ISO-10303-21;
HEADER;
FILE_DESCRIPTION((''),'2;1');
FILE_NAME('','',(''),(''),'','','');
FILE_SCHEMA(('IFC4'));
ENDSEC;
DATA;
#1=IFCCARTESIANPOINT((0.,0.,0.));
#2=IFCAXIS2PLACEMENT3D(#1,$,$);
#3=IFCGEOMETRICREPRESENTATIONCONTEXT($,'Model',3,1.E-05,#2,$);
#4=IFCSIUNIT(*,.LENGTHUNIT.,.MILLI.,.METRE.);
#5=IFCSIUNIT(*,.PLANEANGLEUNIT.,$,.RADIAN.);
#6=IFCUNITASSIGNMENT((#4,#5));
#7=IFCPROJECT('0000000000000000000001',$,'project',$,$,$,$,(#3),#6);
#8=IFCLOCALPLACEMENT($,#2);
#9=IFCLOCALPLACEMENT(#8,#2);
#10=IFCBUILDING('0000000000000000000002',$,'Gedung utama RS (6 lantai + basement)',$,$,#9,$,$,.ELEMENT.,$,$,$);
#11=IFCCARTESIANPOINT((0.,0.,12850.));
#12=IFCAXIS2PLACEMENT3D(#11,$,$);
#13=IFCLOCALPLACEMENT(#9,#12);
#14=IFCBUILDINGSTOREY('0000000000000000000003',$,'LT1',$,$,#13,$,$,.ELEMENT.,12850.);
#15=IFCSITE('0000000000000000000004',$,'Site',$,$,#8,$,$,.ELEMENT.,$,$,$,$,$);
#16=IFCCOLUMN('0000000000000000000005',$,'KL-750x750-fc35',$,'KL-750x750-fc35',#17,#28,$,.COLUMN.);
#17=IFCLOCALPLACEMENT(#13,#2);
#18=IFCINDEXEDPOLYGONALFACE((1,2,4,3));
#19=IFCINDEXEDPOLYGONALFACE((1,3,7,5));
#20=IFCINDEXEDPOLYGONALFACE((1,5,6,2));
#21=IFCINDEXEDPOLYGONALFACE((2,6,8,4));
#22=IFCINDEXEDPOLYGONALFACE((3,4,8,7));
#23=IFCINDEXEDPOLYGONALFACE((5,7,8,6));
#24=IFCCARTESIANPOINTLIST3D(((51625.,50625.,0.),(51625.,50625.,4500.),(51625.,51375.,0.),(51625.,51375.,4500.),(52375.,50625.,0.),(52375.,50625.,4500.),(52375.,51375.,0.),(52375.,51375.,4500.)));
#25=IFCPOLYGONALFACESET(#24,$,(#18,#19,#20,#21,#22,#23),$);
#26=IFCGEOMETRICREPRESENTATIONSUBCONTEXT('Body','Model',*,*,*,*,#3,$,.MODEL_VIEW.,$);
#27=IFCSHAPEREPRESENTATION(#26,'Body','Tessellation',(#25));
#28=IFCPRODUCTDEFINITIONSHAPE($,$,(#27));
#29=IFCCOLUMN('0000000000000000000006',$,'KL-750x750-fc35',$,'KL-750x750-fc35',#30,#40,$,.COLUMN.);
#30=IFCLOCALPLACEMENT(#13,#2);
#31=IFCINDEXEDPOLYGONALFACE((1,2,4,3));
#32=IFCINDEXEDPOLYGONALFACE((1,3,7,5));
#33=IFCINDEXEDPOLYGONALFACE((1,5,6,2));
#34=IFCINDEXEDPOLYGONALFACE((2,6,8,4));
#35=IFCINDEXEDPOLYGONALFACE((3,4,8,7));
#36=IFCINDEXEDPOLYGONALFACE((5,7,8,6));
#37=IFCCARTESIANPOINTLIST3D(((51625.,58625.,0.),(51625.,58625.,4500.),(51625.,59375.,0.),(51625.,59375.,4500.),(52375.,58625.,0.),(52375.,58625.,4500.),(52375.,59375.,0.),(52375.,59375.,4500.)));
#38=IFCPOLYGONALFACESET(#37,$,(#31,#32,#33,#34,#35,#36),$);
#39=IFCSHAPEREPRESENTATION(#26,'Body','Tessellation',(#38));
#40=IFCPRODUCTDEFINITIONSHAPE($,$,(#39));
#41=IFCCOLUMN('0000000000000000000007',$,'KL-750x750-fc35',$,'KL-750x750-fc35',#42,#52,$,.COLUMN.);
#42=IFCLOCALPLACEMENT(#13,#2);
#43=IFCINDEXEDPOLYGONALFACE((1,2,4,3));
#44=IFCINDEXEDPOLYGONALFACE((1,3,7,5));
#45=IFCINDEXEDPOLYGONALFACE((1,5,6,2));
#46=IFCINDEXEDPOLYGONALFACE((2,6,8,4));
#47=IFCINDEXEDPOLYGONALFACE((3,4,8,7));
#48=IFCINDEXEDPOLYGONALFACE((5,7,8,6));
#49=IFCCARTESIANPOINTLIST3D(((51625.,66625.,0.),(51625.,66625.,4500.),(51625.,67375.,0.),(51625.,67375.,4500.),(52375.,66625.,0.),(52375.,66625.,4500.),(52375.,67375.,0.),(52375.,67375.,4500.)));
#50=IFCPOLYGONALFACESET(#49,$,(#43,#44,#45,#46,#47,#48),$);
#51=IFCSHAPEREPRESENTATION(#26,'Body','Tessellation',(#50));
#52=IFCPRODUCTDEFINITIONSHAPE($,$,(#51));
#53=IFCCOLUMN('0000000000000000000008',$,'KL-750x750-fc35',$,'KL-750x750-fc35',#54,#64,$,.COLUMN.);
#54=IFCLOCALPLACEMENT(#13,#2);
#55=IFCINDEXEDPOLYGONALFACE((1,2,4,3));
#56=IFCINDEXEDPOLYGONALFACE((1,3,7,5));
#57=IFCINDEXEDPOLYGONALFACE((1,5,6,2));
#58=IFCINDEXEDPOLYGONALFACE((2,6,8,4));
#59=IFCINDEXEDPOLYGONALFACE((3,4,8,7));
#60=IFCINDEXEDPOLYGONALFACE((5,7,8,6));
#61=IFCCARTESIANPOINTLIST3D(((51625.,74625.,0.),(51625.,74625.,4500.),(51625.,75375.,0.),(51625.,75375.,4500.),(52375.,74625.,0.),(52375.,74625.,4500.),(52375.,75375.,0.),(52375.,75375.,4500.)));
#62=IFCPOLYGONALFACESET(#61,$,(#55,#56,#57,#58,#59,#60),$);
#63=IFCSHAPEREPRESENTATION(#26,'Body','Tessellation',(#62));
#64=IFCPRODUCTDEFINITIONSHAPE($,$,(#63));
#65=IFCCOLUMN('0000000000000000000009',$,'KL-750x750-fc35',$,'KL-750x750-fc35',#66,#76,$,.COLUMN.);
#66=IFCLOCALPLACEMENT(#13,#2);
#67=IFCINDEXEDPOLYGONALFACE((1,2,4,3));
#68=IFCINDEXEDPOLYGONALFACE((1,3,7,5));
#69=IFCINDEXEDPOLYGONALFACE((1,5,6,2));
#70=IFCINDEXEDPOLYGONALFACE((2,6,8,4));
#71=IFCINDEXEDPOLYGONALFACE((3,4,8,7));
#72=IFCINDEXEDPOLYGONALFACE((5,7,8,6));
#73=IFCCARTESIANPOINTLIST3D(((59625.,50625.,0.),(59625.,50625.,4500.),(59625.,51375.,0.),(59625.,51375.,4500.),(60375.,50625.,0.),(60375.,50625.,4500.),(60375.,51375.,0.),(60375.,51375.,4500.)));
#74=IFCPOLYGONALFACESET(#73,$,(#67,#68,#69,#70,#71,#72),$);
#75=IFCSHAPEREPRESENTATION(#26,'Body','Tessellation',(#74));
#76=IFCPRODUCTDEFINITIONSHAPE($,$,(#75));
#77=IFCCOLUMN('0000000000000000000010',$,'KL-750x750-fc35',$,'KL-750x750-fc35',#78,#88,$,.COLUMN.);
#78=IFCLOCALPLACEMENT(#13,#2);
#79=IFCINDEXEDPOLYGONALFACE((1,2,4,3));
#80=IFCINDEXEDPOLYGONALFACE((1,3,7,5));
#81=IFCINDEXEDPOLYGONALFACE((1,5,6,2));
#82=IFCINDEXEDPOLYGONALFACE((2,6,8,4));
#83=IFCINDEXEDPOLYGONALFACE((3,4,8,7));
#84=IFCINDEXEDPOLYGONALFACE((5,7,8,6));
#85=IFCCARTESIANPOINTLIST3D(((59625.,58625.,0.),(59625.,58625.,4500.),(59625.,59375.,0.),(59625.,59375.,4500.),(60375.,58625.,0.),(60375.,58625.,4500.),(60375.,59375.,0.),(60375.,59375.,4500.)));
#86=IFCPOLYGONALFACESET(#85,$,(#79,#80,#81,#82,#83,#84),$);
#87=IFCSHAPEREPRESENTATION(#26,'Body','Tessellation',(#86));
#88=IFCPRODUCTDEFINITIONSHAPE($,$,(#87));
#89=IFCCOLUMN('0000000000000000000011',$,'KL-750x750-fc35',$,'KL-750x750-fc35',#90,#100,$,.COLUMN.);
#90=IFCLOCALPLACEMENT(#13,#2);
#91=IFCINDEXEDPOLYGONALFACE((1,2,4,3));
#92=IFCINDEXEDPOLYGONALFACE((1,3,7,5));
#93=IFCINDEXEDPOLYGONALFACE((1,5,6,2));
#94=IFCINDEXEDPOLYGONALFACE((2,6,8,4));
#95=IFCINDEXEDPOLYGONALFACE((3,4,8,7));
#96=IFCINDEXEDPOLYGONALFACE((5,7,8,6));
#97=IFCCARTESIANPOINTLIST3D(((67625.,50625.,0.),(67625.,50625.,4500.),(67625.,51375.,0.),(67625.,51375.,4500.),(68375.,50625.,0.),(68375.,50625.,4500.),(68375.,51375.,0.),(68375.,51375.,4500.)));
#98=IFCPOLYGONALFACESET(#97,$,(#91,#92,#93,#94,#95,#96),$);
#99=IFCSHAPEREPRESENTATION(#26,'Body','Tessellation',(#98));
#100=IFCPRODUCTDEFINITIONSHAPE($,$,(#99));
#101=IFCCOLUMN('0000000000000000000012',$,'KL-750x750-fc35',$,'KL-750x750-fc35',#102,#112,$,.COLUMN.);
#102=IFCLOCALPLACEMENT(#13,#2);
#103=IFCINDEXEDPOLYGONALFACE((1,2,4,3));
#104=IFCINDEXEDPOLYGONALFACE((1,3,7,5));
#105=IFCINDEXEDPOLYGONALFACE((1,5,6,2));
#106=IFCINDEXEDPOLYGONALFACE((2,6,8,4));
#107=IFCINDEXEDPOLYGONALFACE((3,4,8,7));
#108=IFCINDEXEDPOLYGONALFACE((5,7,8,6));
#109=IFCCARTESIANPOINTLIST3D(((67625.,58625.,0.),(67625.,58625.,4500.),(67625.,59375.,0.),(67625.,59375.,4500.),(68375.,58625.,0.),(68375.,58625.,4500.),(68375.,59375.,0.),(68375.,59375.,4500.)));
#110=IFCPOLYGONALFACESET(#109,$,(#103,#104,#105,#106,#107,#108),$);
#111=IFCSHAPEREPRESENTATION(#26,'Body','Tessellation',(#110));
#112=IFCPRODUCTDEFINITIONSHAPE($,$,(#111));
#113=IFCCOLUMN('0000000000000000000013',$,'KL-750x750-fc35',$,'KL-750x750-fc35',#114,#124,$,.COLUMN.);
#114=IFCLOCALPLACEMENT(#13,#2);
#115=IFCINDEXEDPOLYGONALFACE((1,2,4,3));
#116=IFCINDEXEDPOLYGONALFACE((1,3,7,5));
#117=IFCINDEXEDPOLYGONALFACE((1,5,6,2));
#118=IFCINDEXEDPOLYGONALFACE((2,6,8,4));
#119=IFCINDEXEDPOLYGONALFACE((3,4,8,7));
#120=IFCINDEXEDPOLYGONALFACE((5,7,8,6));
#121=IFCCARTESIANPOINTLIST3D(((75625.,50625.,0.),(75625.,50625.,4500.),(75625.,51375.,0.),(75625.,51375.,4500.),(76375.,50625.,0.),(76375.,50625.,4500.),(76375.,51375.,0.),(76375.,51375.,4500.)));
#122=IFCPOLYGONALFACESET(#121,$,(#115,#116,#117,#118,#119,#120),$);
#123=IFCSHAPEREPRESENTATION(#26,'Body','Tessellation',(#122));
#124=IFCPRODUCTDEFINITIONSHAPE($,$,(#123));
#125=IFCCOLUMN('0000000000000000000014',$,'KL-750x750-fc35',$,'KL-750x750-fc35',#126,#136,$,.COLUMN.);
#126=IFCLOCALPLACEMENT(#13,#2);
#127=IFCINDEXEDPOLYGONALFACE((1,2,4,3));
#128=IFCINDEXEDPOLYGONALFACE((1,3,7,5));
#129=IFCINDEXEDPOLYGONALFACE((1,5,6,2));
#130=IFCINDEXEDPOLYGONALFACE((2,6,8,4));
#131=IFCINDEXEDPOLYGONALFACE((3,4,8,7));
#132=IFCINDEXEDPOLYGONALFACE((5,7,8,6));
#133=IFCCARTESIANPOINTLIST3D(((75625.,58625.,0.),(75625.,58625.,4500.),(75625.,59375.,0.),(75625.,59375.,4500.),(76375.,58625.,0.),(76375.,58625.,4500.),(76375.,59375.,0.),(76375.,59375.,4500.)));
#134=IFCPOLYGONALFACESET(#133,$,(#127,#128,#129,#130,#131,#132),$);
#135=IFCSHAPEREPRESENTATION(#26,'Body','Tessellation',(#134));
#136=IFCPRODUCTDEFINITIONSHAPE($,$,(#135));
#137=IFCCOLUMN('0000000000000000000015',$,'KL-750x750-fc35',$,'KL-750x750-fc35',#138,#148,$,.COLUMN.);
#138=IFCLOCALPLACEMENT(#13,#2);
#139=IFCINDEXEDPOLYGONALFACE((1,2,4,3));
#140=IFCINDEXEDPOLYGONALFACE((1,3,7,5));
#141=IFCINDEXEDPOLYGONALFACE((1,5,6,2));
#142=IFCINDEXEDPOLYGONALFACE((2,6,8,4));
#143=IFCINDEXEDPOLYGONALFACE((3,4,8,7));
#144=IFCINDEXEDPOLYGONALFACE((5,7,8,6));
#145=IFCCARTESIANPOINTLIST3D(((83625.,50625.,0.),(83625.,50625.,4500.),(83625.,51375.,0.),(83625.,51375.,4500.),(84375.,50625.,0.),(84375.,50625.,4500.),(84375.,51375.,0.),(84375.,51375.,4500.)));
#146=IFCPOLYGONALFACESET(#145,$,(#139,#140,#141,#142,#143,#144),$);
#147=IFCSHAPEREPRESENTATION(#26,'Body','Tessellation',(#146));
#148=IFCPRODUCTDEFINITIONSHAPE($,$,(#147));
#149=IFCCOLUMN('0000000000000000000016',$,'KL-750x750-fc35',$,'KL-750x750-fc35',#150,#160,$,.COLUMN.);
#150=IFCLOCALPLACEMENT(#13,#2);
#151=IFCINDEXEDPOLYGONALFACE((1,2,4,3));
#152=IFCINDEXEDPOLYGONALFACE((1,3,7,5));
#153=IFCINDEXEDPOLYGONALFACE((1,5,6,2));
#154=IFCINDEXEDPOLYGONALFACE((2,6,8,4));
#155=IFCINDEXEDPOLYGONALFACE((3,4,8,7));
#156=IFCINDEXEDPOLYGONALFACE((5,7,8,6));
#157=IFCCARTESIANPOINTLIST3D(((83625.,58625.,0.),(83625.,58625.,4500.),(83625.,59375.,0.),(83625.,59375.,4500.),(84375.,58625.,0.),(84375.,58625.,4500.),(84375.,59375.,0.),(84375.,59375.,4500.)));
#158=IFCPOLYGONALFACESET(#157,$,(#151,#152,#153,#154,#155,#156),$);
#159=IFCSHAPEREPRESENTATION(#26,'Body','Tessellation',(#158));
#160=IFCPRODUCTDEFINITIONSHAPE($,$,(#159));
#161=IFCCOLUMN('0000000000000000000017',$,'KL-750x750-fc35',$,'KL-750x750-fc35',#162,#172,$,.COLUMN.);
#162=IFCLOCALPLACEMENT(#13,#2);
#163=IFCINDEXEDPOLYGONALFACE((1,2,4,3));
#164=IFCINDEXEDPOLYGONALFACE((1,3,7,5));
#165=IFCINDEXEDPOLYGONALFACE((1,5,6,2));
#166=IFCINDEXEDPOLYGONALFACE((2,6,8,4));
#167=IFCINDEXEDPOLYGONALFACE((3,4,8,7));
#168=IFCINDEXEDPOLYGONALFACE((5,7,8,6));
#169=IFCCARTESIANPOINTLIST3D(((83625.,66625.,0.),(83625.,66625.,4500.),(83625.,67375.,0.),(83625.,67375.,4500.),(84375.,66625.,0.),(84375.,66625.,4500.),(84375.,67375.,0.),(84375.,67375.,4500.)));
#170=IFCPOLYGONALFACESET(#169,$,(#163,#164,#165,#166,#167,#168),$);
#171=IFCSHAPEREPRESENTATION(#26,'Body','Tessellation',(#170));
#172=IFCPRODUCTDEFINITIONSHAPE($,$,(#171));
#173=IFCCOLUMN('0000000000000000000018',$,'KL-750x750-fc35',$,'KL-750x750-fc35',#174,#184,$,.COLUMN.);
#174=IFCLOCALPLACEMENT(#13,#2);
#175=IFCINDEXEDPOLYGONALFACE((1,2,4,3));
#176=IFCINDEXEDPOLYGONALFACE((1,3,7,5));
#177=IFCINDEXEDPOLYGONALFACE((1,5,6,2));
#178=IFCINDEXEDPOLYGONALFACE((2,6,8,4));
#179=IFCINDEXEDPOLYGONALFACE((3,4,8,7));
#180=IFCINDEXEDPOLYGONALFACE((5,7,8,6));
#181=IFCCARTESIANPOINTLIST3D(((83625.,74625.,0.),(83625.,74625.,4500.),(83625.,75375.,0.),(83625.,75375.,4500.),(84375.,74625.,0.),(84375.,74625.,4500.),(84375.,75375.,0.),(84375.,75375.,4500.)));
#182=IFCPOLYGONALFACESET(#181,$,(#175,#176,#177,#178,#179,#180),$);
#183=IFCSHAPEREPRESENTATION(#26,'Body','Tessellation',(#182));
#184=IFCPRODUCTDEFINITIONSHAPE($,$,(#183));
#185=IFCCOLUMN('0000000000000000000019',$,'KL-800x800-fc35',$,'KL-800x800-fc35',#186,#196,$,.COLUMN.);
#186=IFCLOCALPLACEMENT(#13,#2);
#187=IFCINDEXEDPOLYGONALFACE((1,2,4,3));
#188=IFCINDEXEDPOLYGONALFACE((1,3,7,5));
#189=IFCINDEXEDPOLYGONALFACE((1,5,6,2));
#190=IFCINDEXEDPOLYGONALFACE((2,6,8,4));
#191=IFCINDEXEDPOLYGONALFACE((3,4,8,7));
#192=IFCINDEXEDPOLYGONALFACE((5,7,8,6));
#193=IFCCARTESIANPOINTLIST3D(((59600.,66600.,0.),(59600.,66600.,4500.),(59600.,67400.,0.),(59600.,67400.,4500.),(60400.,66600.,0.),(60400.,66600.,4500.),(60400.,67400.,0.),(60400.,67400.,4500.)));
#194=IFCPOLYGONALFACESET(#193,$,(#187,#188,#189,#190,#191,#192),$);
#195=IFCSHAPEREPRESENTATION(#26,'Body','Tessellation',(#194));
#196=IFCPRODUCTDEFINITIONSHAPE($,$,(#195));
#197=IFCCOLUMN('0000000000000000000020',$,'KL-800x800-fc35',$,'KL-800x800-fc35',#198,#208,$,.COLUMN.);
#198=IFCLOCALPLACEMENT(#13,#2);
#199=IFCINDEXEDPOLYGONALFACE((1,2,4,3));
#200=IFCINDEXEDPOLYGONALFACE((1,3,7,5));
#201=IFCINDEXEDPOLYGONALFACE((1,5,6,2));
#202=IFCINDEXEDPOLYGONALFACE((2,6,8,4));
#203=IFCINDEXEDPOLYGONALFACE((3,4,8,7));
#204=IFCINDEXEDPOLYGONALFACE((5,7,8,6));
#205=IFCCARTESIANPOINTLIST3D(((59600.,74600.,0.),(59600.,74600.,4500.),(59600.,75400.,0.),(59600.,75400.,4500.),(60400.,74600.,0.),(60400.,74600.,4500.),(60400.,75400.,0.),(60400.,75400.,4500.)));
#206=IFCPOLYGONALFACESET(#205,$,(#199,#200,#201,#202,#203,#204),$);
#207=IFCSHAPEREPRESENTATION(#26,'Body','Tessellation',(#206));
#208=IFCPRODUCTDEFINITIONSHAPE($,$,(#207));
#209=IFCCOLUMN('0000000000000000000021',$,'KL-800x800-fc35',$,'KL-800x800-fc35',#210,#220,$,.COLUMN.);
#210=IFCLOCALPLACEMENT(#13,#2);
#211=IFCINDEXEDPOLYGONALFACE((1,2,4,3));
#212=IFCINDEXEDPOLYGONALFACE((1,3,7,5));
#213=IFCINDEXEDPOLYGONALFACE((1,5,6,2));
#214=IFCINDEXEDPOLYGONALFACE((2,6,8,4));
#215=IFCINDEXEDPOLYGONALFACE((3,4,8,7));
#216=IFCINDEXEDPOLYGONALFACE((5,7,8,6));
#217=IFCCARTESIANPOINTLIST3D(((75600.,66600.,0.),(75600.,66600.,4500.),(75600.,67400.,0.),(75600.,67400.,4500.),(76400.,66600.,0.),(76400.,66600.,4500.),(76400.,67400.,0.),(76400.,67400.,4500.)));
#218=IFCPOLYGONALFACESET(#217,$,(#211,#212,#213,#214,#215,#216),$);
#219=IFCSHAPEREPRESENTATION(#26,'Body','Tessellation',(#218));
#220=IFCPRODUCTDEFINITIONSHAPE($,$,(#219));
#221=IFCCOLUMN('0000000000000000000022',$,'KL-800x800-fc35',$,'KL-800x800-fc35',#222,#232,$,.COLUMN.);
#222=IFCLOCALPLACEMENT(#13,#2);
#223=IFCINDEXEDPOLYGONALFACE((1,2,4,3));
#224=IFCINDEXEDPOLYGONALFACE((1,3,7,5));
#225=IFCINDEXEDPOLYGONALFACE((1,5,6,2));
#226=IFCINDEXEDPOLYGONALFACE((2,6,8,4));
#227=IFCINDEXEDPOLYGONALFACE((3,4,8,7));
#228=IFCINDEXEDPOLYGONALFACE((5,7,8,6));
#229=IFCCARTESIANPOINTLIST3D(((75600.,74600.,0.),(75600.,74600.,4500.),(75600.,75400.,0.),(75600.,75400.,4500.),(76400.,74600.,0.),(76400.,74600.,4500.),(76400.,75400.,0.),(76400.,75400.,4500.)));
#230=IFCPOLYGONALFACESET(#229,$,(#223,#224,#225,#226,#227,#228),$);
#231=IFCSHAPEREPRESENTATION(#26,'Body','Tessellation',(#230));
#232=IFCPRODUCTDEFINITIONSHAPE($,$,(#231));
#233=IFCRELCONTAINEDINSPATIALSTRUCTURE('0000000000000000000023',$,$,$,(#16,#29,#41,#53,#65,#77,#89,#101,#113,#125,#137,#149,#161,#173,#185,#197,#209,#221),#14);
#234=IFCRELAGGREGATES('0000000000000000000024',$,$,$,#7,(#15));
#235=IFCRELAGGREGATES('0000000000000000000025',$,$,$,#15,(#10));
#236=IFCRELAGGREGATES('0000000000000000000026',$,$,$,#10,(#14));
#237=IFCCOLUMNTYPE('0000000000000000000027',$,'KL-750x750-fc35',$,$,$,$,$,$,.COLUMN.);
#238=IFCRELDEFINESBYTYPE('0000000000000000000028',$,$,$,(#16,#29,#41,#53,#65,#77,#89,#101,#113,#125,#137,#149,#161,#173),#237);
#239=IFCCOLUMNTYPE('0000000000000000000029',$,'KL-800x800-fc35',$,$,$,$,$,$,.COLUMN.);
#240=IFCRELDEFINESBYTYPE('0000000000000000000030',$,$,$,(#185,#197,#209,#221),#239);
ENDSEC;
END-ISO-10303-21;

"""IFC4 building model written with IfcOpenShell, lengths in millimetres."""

from ifc_helpers import new_model, si_unit, frame, origin, origin_2d, place, context, subcontext, project, spatial, rectangle, extrude, material_profile, profile_set, profile_usage, type_object, element, save


model = new_model("IFC4")

# Units and contexts
model_context = context("Model", 3, precision=1e-05, world=origin())
body_context = subcontext(model_context, "Body", "Model", "MODEL_VIEW")
ifc_project = project(units=[si_unit("LENGTHUNIT", "METRE", prefix="MILLI"), si_unit("PLANEANGLEUNIT", "RADIAN")], contexts=[model_context])

# Site, building, storey
site_placement = place(None, origin())
site = spatial("IfcSite", under=ifc_project, at=site_placement, Name="Site", CompositionType="ELEMENT")
building_placement = place(site_placement, origin())
building = spatial("IfcBuilding", under=site, at=building_placement, Name="Gedung utama RS (6 lantai + basement)", CompositionType="ELEMENT")
storey_placement = place(building_placement, frame((0.0, 0.0, 12850.0)))
storey = spatial("IfcBuildingStorey", under=building, at=storey_placement, Name="LT1", CompositionType="ELEMENT", Elevation=12850.0)

# Columns
ifc_material_profile_1 = material_profile(None, rectangle(XDim=750.0, YDim=750.0, at=origin_2d()), Name="KL-750x750-fc35")
ifc_profile_set_1 = profile_set([ifc_material_profile_1], Name="KL-750x750-fc35")
ifc_profile_usage_1 = profile_usage(ifc_profile_set_1, cardinal=5)
column_type_1 = type_object("IfcColumnType", Name="KL-750x750-fc35", PredefinedType="COLUMN", material=ifc_profile_set_1)
for number, where, z_axis, x_axis, name in (
    (1, (52000.0, 51000.0, 0.0), (0.0, 0.0, 1.0), (1.0, 0.0, 0.0), "KL-750x750-fc35"),
    (2, (52000.0, 59000.0, 0.0), (0.0, 0.0, 1.0), (1.0, 0.0, 0.0), "KL-750x750-fc35"),
    (3, (52000.0, 67000.0, 0.0), (0.0, 0.0, 1.0), (1.0, 0.0, 0.0), "KL-750x750-fc35"),
    (4, (52000.0, 75000.0, 0.0), (0.0, 0.0, 1.0), (1.0, 0.0, 0.0), "KL-750x750-fc35"),
    (5, (60000.0, 51000.0, 0.0), (0.0, 0.0, 1.0), (1.0, 0.0, 0.0), "KL-750x750-fc35"),
    (6, (60000.0, 59000.0, 0.0), (0.0, 0.0, 1.0), (1.0, 0.0, 0.0), "KL-750x750-fc35"),
    (7, (68000.0, 51000.0, 0.0), (0.0, 0.0, 1.0), (1.0, 0.0, 0.0), "KL-750x750-fc35"),
    (8, (68000.0, 59000.0, 0.0), (0.0, 0.0, 1.0), (1.0, 0.0, 0.0), "KL-750x750-fc35"),
    (9, (76000.0, 51000.0, 0.0), (0.0, 0.0, 1.0), (1.0, 0.0, 0.0), "KL-750x750-fc35"),
    (10, (76000.0, 59000.0, 0.0), (0.0, 0.0, 1.0), (1.0, 0.0, 0.0), "KL-750x750-fc35"),
    (11, (84000.0, 51000.0, 0.0), (0.0, 0.0, 1.0), (1.0, 0.0, 0.0), "KL-750x750-fc35"),
    (12, (84000.0, 59000.0, 0.0), (0.0, 0.0, 1.0), (1.0, 0.0, 0.0), "KL-750x750-fc35"),
    (13, (84000.0, 67000.0, 0.0), (0.0, 0.0, 1.0), (1.0, 0.0, 0.0), "KL-750x750-fc35"),
    (14, (84000.0, 75000.0, 0.0), (0.0, 0.0, 1.0), (1.0, 0.0, 0.0), "KL-750x750-fc35"),
):
    element("IfcColumn", number, at=place(storey_placement, frame(where, z_axis=z_axis, x_axis=x_axis)), inside=storey, type_object=column_type_1, material=ifc_profile_usage_1, Name=name, ObjectType="KL-750x750-fc35", PredefinedType="COLUMN", context=body_context, shape_type="SweptSolid", body=[
        extrude(rectangle(XDim=750.0, YDim=750.0, at=origin_2d()), origin(), (0.0, 0.0, 1.0), 4500.0),
    ])
ifc_material_profile_2 = material_profile(None, rectangle(XDim=800.0, YDim=800.0, at=origin_2d()), Name="KL-800x800-fc35")
ifc_profile_set_2 = profile_set([ifc_material_profile_2], Name="KL-800x800-fc35")
ifc_profile_usage_2 = profile_usage(ifc_profile_set_2, cardinal=5)
column_type_2 = type_object("IfcColumnType", Name="KL-800x800-fc35", PredefinedType="COLUMN", material=ifc_profile_set_2)
for number, where, z_axis, x_axis, name in (
    (15, (60000.0, 67000.0, 0.0), (0.0, 0.0, 1.0), (1.0, 0.0, 0.0), "KL-800x800-fc35"),
    (16, (60000.0, 75000.0, 0.0), (0.0, 0.0, 1.0), (1.0, 0.0, 0.0), "KL-800x800-fc35"),
    (17, (76000.0, 67000.0, 0.0), (0.0, 0.0, 1.0), (1.0, 0.0, 0.0), "KL-800x800-fc35"),
    (18, (76000.0, 75000.0, 0.0), (0.0, 0.0, 1.0), (1.0, 0.0, 0.0), "KL-800x800-fc35"),
):
    element("IfcColumn", number, at=place(storey_placement, frame(where, z_axis=z_axis, x_axis=x_axis)), inside=storey, type_object=column_type_2, material=ifc_profile_usage_2, Name=name, ObjectType="KL-800x800-fc35", PredefinedType="COLUMN", context=body_context, shape_type="SweptSolid", body=[
        extrude(rectangle(XDim=800.0, YDim=800.0, at=origin_2d()), origin(), (0.0, 0.0, 1.0), 4500.0),
    ])

save(model, "model.ifc")
